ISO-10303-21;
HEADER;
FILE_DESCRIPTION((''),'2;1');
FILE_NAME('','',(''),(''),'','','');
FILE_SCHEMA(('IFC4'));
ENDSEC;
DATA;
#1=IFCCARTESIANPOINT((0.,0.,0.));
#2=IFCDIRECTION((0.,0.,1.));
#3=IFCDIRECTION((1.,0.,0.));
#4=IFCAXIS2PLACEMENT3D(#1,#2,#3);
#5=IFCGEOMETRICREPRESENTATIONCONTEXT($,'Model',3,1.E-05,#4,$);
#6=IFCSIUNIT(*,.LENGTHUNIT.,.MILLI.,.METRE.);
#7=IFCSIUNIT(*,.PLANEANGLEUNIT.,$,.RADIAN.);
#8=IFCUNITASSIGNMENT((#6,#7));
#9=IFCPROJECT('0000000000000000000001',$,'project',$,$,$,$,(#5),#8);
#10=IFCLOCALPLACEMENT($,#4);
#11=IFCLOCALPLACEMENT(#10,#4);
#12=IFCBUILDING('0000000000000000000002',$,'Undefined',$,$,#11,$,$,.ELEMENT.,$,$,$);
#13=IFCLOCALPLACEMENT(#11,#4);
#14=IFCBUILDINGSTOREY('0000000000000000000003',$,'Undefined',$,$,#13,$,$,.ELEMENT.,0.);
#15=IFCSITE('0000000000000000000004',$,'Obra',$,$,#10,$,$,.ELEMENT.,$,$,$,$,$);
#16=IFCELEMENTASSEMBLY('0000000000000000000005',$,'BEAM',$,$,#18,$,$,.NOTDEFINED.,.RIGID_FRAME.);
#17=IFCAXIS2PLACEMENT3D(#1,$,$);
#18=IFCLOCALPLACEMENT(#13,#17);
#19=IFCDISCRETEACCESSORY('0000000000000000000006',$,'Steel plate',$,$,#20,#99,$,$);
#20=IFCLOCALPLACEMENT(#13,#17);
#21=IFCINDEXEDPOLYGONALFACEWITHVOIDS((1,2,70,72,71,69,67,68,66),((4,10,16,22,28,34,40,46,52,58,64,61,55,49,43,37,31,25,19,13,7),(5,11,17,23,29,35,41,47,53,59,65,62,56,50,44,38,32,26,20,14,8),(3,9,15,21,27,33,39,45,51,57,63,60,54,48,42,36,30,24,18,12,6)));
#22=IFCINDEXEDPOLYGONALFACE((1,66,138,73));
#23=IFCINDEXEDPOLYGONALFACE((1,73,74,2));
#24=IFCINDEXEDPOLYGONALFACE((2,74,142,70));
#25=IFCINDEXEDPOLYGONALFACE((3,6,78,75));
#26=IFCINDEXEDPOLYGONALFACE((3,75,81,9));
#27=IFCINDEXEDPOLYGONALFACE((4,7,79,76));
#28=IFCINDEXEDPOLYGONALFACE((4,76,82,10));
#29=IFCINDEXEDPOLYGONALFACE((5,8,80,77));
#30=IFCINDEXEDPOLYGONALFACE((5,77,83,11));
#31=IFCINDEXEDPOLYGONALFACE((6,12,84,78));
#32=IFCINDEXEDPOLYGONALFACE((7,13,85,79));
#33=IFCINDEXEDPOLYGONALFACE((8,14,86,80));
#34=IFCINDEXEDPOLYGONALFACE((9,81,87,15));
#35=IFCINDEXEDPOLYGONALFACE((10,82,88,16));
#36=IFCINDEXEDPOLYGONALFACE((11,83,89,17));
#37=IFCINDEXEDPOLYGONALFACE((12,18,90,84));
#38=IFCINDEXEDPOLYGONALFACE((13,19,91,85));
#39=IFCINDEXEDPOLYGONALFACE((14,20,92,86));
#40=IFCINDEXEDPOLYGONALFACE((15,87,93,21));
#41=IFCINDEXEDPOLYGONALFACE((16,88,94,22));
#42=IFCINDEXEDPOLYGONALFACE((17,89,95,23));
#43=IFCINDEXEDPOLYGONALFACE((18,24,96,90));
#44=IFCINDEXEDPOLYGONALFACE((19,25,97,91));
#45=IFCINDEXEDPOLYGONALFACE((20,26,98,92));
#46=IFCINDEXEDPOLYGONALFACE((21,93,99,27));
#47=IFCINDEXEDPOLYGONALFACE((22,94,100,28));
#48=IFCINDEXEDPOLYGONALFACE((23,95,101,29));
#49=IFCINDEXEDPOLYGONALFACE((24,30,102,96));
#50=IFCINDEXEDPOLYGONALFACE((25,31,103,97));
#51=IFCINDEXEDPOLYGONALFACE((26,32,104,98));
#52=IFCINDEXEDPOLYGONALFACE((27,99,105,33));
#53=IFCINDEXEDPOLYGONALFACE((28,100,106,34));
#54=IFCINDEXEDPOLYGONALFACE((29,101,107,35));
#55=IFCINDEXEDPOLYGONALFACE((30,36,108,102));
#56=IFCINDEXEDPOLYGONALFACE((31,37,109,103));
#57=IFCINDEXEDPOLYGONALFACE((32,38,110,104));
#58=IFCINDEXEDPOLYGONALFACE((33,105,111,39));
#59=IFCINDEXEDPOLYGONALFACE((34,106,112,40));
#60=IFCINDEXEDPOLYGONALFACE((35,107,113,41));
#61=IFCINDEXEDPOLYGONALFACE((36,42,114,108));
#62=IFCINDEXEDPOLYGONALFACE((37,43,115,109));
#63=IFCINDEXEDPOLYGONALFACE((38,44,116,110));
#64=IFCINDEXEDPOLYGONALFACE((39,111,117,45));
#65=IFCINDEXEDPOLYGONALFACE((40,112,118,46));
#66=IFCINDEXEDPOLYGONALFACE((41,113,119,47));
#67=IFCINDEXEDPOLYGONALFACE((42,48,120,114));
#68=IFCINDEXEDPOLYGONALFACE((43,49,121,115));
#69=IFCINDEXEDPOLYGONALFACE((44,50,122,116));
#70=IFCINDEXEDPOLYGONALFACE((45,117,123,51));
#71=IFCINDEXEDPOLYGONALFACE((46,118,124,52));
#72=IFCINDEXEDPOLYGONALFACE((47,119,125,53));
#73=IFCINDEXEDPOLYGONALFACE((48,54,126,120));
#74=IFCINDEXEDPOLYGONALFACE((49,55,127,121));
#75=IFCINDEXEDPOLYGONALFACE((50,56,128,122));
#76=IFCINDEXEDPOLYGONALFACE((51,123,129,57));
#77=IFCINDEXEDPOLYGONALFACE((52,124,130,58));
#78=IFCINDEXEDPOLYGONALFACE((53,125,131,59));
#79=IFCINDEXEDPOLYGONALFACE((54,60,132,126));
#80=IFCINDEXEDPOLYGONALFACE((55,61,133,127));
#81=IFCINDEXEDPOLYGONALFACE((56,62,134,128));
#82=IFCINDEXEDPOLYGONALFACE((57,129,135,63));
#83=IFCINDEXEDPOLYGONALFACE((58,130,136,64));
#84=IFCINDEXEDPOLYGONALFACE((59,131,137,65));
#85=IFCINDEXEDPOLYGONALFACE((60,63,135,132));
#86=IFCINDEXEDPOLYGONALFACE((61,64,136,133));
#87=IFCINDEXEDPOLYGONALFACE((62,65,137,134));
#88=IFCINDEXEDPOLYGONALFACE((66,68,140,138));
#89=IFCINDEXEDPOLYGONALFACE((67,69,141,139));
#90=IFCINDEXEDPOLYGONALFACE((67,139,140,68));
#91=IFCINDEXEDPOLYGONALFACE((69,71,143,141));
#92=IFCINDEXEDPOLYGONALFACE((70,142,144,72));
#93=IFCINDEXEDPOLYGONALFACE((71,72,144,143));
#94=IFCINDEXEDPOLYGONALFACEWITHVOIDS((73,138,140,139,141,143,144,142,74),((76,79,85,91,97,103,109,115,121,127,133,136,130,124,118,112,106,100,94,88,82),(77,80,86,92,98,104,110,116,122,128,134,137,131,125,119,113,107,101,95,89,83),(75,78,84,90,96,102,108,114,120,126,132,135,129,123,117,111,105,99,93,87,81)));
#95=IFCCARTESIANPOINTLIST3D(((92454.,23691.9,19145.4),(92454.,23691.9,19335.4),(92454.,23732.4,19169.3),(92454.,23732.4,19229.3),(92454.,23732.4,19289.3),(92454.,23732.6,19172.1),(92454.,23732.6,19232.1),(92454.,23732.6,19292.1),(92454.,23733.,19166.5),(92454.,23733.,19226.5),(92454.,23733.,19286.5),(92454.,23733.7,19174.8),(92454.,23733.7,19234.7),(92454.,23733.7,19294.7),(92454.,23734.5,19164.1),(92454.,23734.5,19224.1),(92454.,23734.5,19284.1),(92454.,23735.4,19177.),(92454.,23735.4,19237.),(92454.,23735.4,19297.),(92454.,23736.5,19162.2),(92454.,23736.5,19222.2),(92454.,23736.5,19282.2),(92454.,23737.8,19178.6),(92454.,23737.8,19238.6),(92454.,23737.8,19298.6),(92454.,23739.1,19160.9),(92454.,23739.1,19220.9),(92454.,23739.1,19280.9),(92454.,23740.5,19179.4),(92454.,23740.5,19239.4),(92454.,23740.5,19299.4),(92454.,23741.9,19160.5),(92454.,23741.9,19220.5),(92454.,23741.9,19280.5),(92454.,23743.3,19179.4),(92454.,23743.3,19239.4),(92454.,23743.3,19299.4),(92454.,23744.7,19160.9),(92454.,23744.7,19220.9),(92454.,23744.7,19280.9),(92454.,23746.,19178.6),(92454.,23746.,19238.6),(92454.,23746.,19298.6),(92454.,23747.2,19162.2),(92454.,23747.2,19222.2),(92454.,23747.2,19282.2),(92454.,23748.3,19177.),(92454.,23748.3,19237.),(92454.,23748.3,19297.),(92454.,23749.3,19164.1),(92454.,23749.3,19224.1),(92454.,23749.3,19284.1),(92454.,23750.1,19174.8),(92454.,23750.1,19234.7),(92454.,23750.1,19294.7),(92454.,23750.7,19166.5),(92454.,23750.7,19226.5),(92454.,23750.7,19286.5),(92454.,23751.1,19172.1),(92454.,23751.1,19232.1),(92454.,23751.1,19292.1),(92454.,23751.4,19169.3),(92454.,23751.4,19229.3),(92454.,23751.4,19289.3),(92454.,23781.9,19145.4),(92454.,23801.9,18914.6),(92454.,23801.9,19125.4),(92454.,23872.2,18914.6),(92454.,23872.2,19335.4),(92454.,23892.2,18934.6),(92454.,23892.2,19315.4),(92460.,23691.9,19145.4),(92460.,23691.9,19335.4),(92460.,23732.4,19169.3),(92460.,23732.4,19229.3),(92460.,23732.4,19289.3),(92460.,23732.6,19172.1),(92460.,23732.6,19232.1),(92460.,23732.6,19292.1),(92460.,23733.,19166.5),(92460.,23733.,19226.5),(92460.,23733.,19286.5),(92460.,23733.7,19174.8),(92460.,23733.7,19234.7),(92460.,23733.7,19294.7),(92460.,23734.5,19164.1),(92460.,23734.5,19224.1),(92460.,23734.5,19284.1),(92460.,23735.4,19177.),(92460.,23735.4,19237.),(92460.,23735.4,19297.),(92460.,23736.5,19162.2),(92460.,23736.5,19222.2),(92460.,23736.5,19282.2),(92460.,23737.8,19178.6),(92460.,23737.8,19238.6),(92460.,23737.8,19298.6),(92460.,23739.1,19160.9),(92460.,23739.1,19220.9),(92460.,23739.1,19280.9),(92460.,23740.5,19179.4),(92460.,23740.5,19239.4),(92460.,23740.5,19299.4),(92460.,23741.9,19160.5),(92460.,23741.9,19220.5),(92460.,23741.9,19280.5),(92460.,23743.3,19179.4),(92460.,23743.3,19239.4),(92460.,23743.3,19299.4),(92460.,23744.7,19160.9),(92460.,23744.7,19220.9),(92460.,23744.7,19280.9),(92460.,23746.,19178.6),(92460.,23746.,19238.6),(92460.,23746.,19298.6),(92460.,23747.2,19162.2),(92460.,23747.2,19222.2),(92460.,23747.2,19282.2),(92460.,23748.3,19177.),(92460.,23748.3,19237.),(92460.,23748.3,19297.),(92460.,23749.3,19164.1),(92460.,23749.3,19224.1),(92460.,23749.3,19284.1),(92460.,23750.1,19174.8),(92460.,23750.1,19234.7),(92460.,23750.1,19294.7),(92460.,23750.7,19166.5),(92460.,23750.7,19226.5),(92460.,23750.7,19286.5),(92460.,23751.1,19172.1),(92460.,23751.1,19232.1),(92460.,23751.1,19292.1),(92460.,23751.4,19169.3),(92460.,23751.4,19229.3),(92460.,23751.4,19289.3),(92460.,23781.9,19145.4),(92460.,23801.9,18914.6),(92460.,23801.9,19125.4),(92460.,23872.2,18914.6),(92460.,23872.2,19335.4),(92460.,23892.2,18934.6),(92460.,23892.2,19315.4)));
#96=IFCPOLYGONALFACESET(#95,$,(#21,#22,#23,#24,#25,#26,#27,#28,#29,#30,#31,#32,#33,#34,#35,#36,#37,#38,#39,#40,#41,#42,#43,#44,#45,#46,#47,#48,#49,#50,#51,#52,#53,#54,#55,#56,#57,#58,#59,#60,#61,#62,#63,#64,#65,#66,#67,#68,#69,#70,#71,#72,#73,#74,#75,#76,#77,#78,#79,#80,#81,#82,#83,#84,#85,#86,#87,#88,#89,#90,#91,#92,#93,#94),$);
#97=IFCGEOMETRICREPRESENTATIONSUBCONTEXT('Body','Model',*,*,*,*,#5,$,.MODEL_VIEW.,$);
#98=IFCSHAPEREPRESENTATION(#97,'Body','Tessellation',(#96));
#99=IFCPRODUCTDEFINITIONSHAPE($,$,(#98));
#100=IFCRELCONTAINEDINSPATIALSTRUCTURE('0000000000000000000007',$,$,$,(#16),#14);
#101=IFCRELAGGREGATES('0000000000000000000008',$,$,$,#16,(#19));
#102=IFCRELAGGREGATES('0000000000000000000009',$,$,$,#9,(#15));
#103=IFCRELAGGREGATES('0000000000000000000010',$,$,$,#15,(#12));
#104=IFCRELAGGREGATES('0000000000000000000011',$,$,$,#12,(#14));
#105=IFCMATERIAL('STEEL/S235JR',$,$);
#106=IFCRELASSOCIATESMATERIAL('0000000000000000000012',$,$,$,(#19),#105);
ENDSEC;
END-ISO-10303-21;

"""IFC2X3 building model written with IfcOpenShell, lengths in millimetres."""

from ifc_helpers import new_model, si_unit, frame, origin_with_axes, origin_2d_with_axis, place, context, subcontext, project, spatial, polyline, circle, outline, extrude, source, transform, mapped, material, element, aggregate, save


model = new_model("IFC2X3")

# Units and contexts
model_context = context("Model", 3, precision=1e-05, world=origin_with_axes())
body_context = subcontext(model_context, "Body", "Model", "MODEL_VIEW")
ifc_project = project(units=[si_unit("LENGTHUNIT", "METRE", prefix="MILLI"), si_unit("PLANEANGLEUNIT", "RADIAN")], contexts=[model_context])

# Site, building, storey
site_placement = place(None, origin_with_axes())
site = spatial("IfcSite", under=ifc_project, at=site_placement, Name="Obra", CompositionType="ELEMENT")
building_placement = place(site_placement, origin_with_axes())
building = spatial("IfcBuilding", under=site, at=building_placement, Name="Undefined", CompositionType="ELEMENT")
storey_placement = place(building_placement, origin_with_axes())
storey = spatial("IfcBuildingStorey", under=building, at=storey_placement, Name="Undefined", CompositionType="ELEMENT", Elevation=0.0)

# Shared definitions
ifc_material_1 = material(Name="STEEL/S235JR")

# Element assembly
assembly_1_placement = place(storey_placement, origin_with_axes())
assembly_1 = element("IfcElementAssembly", 1, at=assembly_1_placement, inside=storey, Name="BEAM", AssemblyPlace="NOTDEFINED", PredefinedType="RIGID_FRAME")

# Discrete accessory, opening
discrete_accessory_1_placement = place(assembly_1_placement, frame((92457.0, 23892.2, 18934.6), z_axis=(-1.0, 0.0, 0.0), x_axis=(0.000001, -0.707107, -0.707107)))
discrete_accessory_1 = element("IfcDiscreteAccessory", 2, at=discrete_accessory_1_placement, material=ifc_material_1, Name="Steel plate", context=body_context, shape_type="SweptSolid", body=[
    extrude(outline(polyline([(0.0, 0.0), (28.3, 0.0), (78.0, 49.7), (-71.1, 198.8), (-71.1, 227.1), (-7.4, 290.7), (-141.8, 425.0), (-269.3, 297.6), (-269.3, 269.3), (0.0, 0.0)])), frame((0.0, 0.0, -3.0), z_axis=(0.0, 0.0, 1.0), x_axis=(1.0, 0.0, 0.0)), (0.0, 0.0, 1.0), 6.0),
])
shared_shape_1 = source(origin_with_axes(), body_context, "Body", "SweptSolid", [
    extrude(circle(Radius=9.5, at=origin_2d_with_axis()), frame((0.0, -9.2, 0.0), z_axis=(0.0, 1.0, 0.0), x_axis=(1.0, 0.0, 0.0)), (0.0, 0.0, 1.0), 6.2),
])
opening_1_placement = place(assembly_1_placement, frame((92463.1, 23791.9, 19335.4), z_axis=(0.0, -1.0, 0.0), x_axis=(0.0, 0.0, -1.0)))
element("IfcOpeningElement", 3, at=opening_1_placement, cuts=discrete_accessory_1, ObjectType="Opening", context=body_context, shape_type="MappedRepresentation", body=[
    mapped(shared_shape_1, transform((165.4, 0.0, 50.0))),
    mapped(shared_shape_1, transform((105.4, 0.0, 50.0))),
    mapped(shared_shape_1, transform((45.4, 0.0, 50.0))),
])
aggregate(assembly_1, [discrete_accessory_1])

save(model, "model.ifc")
